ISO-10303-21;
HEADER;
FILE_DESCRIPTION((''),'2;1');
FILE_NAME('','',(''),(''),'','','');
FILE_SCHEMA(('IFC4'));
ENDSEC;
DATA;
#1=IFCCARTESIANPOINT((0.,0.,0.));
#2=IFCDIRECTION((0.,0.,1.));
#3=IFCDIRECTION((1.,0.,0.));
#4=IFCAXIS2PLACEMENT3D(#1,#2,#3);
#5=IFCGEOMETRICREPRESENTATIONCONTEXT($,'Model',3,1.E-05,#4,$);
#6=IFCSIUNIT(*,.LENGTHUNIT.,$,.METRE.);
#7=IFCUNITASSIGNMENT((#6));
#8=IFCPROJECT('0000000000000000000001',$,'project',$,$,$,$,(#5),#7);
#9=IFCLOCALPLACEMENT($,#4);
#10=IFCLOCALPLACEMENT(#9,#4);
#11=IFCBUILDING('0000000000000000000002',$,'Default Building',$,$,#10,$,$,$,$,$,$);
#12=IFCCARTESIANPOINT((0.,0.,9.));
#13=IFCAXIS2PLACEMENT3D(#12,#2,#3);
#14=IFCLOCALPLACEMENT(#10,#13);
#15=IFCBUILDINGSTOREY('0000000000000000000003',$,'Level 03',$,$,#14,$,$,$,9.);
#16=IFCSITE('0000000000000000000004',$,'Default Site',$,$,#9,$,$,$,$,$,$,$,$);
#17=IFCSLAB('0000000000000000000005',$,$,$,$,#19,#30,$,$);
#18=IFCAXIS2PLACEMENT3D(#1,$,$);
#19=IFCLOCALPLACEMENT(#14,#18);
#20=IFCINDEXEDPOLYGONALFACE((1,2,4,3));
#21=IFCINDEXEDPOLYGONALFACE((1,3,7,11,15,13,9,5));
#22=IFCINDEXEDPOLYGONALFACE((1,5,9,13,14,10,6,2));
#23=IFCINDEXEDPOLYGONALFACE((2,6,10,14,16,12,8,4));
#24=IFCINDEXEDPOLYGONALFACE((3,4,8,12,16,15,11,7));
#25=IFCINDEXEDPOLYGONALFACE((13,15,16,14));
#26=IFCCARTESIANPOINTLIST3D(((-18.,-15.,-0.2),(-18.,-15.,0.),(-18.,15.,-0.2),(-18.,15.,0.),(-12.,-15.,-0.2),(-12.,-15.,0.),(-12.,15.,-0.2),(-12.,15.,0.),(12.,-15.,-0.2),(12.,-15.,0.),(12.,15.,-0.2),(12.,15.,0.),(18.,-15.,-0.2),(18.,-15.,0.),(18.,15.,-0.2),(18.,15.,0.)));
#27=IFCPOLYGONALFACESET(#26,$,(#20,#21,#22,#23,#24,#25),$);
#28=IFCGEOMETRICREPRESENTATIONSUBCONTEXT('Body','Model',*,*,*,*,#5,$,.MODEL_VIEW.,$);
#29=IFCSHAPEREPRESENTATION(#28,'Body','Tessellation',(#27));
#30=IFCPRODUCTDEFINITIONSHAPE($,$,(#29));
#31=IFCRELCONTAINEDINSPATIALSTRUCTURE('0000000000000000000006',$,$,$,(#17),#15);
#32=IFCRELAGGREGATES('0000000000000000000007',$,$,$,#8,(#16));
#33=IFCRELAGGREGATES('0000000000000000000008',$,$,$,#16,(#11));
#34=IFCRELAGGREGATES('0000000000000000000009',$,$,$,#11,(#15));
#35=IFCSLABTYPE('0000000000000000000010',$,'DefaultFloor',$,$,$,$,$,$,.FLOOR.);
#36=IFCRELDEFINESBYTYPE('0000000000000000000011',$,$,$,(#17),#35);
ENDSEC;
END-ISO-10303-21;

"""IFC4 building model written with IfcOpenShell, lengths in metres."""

from ifc_helpers import new_model, si_unit, frame, origin_with_axes, place, context, subcontext, project, spatial, polyline, outline, extrude, type_object, element, save


model = new_model("IFC4")

# Units and contexts
model_context = context("Model", 3, precision=1e-05, world=origin_with_axes())
body_context = subcontext(model_context, "Body", "Model", "MODEL_VIEW")
ifc_project = project(units=[si_unit("LENGTHUNIT", "METRE")], contexts=[model_context])

# Site, building, storey
site_placement = place(None, origin_with_axes())
site = spatial("IfcSite", under=ifc_project, at=site_placement, Name="Default Site")
building_placement = place(site_placement, origin_with_axes())
building = spatial("IfcBuilding", under=site, at=building_placement, Name="Default Building")
storey_placement = place(building_placement, frame((0.0, 0.0, 9.0), z_axis=(0.0, 0.0, 1.0), x_axis=(1.0, 0.0, 0.0)))
storey = spatial("IfcBuildingStorey", under=building, at=storey_placement, Name="Level 03", Elevation=9.0)

# Slab
slab_type = type_object("IfcSlabType", Name="DefaultFloor", PredefinedType="FLOOR")
slab_placement = place(storey_placement, frame((0.0, 0.0, -9.0), z_axis=(0.0, 0.0, 1.0), x_axis=(1.0, 0.0, 0.0)))
element("IfcSlab", 1, at=slab_placement, inside=storey, type_object=slab_type, context=body_context, shape_type="SweptSolid", body=[
    extrude(outline(polyline([(-18.0, 15.0), (-12.0, 15.0), (12.0, 15.0), (18.0, 15.0), (18.0, -15.0), (12.0, -15.0), (-12.0, -15.0), (-18.0, -15.0), (-18.0, 15.0)])), frame((0.0, 0.0, 9.0), z_axis=(0.0, 0.0, 1.0), x_axis=(1.0, 0.0, 0.0)), (0.0, 0.0, -1.0), 0.2),
])

save(model, "model.ifc")
